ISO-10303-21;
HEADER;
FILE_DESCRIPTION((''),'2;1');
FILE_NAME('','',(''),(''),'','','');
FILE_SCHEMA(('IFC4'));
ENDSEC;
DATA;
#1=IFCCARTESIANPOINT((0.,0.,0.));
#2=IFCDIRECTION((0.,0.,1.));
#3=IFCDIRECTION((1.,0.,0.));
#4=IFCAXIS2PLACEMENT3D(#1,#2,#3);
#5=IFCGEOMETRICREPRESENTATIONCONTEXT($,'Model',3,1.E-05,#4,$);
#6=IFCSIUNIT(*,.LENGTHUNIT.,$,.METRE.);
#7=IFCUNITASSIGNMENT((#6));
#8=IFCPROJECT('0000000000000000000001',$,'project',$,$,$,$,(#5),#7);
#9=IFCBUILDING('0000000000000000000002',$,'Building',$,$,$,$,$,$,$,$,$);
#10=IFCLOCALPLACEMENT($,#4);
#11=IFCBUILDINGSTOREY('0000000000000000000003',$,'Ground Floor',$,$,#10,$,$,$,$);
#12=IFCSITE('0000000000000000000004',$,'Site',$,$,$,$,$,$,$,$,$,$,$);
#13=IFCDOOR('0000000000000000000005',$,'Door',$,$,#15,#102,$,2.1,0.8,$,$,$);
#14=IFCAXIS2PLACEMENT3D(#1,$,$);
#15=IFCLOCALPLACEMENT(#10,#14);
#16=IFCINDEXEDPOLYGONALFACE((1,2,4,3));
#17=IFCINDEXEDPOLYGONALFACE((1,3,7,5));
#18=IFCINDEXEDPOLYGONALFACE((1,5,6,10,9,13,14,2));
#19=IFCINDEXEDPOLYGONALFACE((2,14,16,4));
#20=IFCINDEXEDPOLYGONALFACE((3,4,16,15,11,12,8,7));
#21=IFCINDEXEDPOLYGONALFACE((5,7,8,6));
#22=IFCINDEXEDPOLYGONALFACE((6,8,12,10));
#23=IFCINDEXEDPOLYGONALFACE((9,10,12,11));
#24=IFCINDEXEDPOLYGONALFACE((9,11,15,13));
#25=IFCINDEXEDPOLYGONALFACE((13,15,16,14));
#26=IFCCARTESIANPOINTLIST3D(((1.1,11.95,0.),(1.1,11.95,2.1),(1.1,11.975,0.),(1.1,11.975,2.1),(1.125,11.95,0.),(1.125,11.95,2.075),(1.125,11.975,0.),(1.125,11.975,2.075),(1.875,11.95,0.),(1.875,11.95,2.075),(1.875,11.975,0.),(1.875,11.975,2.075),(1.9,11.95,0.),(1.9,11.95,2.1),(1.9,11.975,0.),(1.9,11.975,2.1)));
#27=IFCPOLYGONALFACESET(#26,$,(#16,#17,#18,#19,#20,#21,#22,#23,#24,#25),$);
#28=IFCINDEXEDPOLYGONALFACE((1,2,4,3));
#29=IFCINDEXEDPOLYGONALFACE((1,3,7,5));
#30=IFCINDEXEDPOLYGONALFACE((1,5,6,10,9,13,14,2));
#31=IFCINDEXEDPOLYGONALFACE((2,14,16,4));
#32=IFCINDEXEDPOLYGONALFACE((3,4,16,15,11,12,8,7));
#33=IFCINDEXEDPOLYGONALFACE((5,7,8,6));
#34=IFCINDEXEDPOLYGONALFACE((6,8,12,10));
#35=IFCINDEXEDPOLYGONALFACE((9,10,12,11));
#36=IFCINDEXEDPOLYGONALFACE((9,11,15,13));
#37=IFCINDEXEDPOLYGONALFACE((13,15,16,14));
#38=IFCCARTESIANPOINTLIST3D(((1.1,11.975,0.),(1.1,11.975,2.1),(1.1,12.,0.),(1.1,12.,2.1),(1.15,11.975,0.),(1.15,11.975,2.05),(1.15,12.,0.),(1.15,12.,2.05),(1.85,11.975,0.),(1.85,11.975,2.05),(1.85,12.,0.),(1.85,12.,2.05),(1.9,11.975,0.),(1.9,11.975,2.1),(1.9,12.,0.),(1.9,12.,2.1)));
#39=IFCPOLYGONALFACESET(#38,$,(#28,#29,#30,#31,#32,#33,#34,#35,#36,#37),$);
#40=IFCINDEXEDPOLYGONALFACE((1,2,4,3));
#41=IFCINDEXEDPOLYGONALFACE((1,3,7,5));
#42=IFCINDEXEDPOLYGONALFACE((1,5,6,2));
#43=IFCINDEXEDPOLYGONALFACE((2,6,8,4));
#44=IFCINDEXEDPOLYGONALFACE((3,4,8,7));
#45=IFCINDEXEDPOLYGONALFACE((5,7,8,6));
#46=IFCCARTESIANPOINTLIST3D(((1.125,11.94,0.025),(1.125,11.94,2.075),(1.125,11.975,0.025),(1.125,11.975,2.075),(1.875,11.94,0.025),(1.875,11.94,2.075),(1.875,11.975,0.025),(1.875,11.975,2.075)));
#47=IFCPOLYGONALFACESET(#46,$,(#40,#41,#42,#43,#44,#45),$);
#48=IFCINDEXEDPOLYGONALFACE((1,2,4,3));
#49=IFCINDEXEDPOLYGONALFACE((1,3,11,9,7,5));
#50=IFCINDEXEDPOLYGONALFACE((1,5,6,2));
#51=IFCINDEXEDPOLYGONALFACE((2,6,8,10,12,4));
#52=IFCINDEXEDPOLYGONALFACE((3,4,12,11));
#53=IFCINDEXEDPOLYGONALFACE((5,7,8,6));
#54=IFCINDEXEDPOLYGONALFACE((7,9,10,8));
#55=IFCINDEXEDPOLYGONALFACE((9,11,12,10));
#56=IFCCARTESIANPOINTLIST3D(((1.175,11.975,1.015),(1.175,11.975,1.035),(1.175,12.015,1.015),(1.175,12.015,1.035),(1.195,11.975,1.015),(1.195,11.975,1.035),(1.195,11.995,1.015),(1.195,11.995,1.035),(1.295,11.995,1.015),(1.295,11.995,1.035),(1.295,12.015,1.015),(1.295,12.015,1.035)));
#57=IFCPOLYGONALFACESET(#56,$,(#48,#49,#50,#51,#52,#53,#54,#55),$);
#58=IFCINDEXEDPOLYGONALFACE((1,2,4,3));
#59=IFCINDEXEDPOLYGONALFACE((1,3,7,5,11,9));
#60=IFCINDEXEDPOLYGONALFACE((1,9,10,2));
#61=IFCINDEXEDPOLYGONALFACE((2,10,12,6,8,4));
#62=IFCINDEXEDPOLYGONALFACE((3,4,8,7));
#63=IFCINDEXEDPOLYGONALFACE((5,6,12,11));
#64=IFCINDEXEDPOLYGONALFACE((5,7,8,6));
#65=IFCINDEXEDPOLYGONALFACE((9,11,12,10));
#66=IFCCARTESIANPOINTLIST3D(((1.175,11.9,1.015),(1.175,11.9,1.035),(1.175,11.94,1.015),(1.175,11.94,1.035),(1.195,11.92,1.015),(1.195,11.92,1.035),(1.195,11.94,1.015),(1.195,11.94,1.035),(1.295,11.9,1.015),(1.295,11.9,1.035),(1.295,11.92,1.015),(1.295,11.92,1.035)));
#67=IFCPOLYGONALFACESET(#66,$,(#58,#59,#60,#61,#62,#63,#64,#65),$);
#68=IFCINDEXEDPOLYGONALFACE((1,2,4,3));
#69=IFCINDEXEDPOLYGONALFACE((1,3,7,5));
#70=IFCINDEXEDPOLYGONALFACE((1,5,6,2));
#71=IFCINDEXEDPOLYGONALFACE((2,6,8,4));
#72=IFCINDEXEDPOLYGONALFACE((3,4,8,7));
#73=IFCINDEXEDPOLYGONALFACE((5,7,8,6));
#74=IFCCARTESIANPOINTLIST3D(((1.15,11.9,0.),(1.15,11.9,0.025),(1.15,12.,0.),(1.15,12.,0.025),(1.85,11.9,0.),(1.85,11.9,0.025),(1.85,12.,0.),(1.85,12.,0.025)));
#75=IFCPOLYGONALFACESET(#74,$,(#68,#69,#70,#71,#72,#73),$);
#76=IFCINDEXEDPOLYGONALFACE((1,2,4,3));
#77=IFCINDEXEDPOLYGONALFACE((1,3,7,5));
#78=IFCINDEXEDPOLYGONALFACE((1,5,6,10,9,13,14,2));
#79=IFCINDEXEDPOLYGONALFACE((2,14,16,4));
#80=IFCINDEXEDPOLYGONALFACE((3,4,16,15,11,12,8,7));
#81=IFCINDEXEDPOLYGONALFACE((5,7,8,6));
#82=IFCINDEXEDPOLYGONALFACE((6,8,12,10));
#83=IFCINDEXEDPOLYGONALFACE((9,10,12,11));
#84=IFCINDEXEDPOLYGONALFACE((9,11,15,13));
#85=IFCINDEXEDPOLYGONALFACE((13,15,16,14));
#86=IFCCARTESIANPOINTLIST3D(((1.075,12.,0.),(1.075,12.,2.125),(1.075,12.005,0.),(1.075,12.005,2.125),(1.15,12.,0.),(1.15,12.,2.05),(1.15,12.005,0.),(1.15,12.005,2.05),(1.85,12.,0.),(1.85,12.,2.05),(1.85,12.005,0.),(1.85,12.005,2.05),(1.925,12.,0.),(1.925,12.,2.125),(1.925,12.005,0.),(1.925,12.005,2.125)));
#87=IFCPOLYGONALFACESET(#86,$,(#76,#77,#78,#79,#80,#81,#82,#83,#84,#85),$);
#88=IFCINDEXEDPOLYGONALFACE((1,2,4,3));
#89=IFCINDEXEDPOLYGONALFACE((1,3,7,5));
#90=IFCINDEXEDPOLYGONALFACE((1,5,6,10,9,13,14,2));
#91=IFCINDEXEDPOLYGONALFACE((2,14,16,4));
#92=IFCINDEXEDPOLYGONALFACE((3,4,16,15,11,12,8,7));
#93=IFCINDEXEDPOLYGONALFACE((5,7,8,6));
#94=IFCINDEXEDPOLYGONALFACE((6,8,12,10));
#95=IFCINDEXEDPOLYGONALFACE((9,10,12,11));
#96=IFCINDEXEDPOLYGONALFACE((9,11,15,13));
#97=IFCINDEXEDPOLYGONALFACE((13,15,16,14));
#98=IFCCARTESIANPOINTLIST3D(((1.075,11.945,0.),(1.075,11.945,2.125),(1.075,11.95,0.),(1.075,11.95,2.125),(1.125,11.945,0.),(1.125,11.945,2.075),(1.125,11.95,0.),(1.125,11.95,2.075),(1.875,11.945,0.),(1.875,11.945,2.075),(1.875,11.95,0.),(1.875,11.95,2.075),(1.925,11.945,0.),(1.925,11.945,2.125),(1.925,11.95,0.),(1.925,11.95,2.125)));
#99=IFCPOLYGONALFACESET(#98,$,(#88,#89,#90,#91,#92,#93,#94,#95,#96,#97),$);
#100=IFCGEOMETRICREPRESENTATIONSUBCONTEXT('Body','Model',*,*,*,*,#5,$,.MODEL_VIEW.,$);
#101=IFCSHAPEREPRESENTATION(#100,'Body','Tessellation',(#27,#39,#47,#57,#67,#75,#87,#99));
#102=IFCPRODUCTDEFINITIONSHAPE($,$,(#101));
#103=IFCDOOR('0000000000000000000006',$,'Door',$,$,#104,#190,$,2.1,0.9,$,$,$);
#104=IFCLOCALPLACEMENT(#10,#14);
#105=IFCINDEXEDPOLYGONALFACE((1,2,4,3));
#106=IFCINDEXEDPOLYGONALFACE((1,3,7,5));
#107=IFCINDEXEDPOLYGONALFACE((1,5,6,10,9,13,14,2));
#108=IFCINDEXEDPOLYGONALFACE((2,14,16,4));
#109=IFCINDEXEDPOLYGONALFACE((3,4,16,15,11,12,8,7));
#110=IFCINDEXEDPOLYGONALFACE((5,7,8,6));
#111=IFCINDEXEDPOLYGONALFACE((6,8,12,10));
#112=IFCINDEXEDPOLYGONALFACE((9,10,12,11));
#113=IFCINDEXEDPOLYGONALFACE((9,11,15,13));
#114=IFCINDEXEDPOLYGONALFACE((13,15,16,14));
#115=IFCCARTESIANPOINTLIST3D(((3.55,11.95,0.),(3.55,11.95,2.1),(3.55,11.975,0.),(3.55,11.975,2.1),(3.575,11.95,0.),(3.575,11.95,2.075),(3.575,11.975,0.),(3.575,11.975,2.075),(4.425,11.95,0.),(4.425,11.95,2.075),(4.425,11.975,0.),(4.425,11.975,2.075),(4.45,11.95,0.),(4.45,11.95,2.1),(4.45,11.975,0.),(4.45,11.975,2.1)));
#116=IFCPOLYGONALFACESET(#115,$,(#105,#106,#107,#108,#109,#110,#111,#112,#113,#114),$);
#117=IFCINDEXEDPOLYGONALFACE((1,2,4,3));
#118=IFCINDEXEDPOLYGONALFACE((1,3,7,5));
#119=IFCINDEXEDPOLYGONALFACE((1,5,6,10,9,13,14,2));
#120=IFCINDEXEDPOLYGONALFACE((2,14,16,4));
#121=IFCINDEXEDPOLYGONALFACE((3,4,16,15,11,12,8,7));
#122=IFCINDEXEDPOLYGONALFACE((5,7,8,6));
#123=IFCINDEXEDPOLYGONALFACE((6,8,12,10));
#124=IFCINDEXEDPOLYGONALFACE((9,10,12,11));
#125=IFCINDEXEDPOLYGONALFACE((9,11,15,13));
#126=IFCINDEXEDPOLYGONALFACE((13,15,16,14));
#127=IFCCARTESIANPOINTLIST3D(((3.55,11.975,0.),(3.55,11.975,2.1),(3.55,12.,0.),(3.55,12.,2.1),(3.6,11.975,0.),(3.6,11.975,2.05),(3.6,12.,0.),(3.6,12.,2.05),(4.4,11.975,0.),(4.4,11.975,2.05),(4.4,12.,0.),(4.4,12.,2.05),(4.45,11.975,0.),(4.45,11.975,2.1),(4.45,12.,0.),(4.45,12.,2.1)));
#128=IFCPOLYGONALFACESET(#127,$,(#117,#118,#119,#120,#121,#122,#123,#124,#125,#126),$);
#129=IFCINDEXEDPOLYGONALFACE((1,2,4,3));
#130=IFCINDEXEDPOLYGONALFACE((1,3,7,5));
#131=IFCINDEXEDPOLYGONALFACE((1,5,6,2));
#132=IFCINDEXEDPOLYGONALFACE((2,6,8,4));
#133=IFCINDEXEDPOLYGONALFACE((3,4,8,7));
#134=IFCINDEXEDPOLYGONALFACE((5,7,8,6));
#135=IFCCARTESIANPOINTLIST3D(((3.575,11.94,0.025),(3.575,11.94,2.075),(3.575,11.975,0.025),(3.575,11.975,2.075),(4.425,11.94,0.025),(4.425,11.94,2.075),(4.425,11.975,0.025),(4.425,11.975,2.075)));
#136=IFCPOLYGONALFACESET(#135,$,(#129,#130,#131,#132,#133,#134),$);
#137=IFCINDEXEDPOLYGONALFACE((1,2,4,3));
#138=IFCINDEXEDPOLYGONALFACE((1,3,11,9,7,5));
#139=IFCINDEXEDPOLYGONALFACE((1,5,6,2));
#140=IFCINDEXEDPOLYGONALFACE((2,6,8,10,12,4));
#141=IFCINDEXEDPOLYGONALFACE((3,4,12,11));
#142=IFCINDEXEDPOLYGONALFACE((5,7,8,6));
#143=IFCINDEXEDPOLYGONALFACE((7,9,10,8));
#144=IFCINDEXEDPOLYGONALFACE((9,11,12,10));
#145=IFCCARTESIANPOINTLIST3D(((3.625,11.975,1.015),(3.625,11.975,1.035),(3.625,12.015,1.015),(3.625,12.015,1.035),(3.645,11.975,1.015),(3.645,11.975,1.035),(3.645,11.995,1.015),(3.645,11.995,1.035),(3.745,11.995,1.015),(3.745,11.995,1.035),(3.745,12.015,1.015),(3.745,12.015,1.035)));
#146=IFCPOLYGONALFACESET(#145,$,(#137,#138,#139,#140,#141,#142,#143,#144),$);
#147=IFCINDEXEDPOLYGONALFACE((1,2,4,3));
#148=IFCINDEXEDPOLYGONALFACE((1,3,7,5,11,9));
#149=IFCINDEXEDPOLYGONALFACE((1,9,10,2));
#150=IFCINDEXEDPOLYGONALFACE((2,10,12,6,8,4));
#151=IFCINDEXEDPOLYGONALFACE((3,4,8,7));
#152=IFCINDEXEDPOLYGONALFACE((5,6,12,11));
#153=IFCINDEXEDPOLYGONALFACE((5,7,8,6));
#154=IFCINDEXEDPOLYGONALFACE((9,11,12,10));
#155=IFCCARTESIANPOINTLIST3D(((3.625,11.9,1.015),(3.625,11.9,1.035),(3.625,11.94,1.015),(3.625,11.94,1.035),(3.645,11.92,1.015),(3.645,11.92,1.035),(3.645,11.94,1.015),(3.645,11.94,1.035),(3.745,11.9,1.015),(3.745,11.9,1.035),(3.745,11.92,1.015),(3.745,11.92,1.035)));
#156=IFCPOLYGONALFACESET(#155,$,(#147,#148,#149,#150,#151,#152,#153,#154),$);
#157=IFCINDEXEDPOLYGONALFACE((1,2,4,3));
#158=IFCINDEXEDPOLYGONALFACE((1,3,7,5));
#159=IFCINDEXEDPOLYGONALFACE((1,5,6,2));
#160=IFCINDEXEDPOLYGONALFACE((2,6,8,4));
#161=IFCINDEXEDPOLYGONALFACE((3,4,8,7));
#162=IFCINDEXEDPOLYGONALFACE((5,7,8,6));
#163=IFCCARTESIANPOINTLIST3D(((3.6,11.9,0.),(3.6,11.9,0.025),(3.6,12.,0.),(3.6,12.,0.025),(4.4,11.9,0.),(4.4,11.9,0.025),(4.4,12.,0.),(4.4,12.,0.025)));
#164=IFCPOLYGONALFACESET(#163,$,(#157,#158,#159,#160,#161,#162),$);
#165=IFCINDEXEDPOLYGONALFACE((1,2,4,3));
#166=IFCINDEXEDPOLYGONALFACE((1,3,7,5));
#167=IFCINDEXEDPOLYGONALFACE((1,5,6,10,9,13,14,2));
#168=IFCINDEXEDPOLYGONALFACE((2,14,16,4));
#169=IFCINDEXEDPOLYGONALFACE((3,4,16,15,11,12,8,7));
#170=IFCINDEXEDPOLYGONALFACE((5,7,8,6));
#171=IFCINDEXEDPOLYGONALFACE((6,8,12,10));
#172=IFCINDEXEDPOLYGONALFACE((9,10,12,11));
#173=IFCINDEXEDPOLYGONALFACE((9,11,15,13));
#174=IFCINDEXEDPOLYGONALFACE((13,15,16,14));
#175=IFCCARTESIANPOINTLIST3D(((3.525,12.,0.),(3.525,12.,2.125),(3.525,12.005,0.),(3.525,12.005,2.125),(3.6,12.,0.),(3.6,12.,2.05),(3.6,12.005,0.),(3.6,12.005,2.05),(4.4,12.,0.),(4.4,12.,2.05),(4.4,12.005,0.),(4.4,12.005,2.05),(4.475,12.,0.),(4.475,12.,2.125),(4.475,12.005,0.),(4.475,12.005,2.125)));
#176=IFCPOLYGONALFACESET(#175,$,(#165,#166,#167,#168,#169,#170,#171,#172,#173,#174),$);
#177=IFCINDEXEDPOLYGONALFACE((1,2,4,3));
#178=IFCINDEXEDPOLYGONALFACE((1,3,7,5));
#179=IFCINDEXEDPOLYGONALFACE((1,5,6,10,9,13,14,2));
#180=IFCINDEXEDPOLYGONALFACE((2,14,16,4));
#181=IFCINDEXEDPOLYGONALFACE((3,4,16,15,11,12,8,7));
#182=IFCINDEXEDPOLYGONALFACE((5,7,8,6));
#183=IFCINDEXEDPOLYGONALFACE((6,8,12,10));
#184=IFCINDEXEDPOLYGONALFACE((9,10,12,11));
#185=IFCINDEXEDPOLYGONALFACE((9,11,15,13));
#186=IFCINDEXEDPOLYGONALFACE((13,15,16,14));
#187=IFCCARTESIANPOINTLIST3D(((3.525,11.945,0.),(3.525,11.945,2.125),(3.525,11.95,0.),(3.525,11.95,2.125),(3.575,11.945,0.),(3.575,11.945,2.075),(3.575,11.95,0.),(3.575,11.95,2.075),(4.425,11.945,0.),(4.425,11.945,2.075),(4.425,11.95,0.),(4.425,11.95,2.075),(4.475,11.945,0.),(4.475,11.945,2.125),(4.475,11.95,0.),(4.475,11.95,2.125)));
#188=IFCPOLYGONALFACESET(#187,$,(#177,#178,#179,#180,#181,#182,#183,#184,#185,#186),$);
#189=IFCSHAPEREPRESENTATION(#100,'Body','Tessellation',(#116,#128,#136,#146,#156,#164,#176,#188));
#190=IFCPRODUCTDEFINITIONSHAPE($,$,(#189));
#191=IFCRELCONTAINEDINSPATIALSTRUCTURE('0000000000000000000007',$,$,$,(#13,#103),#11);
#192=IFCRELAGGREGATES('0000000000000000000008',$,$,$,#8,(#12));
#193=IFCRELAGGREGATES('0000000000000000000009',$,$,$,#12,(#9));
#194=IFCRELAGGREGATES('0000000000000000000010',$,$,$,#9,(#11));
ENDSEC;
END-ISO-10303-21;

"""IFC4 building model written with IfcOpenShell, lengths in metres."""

from ifc_helpers import new_model, si_unit, frame, origin_with_axes, place, context, subcontext, project, spatial, line, indexed_curve, outline, extrude, element, save


model = new_model("IFC4")

# Units and contexts
model_context = context("Model", 3, precision=1e-05, world=origin_with_axes())
body_context = subcontext(model_context, "Body", "Model", "MODEL_VIEW")
ifc_project = project(units=[si_unit("LENGTHUNIT", "METRE")], contexts=[model_context])

# Site, building, storey
site = spatial("IfcSite", under=ifc_project, Name="Site")
building = spatial("IfcBuilding", under=site, Name="Building")
storey_placement = place(None, origin_with_axes())
storey = spatial("IfcBuildingStorey", under=building, at=storey_placement, Name="Ground Floor")

# Doors
door_1_placement = place(storey_placement, frame((1.9, 12.0, 0.0), z_axis=(0.0, 0.0, 1.0), x_axis=(-1.0, 0.0, 0.0)))
element("IfcDoor", 1, at=door_1_placement, inside=storey, Name="Door", OverallHeight=2.1, OverallWidth=0.8, context=body_context, shape_type="SweptSolid", body=[
    extrude(outline(indexed_curve([(0.0, 0.0), (0.0, 2.1), (0.8, 2.1), (0.8, 0.0), (0.775, 0.0), (0.775, 2.075), (0.025, 2.075), (0.025, 0.0)], segments=[line(1, 2, 3, 4, 5, 6, 7, 8, 1)])), frame((0.0, 0.025, 0.0), z_axis=(0.0, -1.0, 0.0), x_axis=(1.0, 0.0, 0.0)), (0.0, 0.0, -1.0), 0.025),
    extrude(outline(indexed_curve([(0.0, 0.0), (0.0, 2.1), (0.8, 2.1), (0.8, 0.0), (0.75, 0.0), (0.75, 2.05), (0.05, 2.05), (0.05, 0.0)], segments=[line(1, 2, 3, 4, 5, 6, 7, 8, 1)])), frame((0.0, 0.0, 0.0), z_axis=(0.0, -1.0, 0.0), x_axis=(1.0, 0.0, 0.0)), (0.0, 0.0, -1.0), 0.025),
    extrude(outline(indexed_curve([(0.0, 0.0), (0.75, 0.0), (0.75, 0.035), (0.0, 0.035)], segments=[line(1, 2, 3, 4, 1)])), frame((0.025, 0.025, 0.025), z_axis=(0.0, 0.0, 1.0), x_axis=(1.0, 0.0, 0.0)), (0.0, 0.0, 1.0), 2.05),
    extrude(outline(indexed_curve([(0.0, 0.0), (0.0, -0.04), (-0.12, -0.04), (-0.12, -0.02), (-0.02, -0.02), (-0.02, 0.0)], segments=[line(1, 2, 3, 4, 5, 6, 1)])), frame((0.725, 0.025, 1.015), z_axis=(0.0, 0.0, 1.0), x_axis=(1.0, 0.0, 0.0)), (0.0, 0.0, 1.0), 0.02),
    extrude(outline(indexed_curve([(0.0, 0.0), (0.0, 0.04), (-0.12, 0.04), (-0.12, 0.02), (-0.02, 0.02), (-0.02, 0.0)], segments=[line(1, 2, 3, 4, 5, 6, 1)])), frame((0.725, 0.06, 1.015), z_axis=(0.0, 0.0, 1.0), x_axis=(1.0, 0.0, 0.0)), (0.0, 0.0, 1.0), 0.02),
    extrude(outline(indexed_curve([(0.0, 0.0), (0.7, 0.0), (0.7, 0.1), (0.0, 0.1)], segments=[line(1, 2, 3, 4, 1)])), frame((0.05, 0.0, 0.0), z_axis=(0.0, 0.0, 1.0), x_axis=(1.0, 0.0, 0.0)), (0.0, 0.0, 1.0), 0.025),
    extrude(outline(indexed_curve([(0.0, 0.0), (0.0, 2.125), (0.85, 2.125), (0.85, 0.0), (0.775, 0.0), (0.775, 2.05), (0.075, 2.05), (0.075, 0.0)], segments=[line(1, 2, 3, 4, 5, 6, 7, 8, 1)])), frame((-0.025, -0.005, 0.0), z_axis=(0.0, -1.0, 0.0), x_axis=(1.0, 0.0, 0.0)), (0.0, 0.0, -1.0), 0.005),
    extrude(outline(indexed_curve([(0.0, 0.0), (0.0, 2.125), (0.85, 2.125), (0.85, 0.0), (0.8, 0.0), (0.8, 2.075), (0.05, 2.075), (0.05, 0.0)], segments=[line(1, 2, 3, 4, 5, 6, 7, 8, 1)])), frame((-0.025, 0.05, 0.0), z_axis=(0.0, -1.0, 0.0), x_axis=(1.0, 0.0, 0.0)), (0.0, 0.0, -1.0), 0.005),
])
door_2_placement = place(storey_placement, frame((4.45, 12.0, 0.0), z_axis=(0.0, 0.0, 1.0), x_axis=(-1.0, 0.0, 0.0)))
element("IfcDoor", 2, at=door_2_placement, inside=storey, Name="Door", OverallHeight=2.1, OverallWidth=0.9, context=body_context, shape_type="SweptSolid", body=[
    extrude(outline(indexed_curve([(0.0, 0.0), (0.0, 2.1), (0.9, 2.1), (0.9, 0.0), (0.875, 0.0), (0.875, 2.075), (0.025, 2.075), (0.025, 0.0)], segments=[line(1, 2, 3, 4, 5, 6, 7, 8, 1)])), frame((0.0, 0.025, 0.0), z_axis=(0.0, -1.0, 0.0), x_axis=(1.0, 0.0, 0.0)), (0.0, 0.0, -1.0), 0.025),
    extrude(outline(indexed_curve([(0.0, 0.0), (0.0, 2.1), (0.9, 2.1), (0.9, 0.0), (0.85, 0.0), (0.85, 2.05), (0.05, 2.05), (0.05, 0.0)], segments=[line(1, 2, 3, 4, 5, 6, 7, 8, 1)])), frame((0.0, 0.0, 0.0), z_axis=(0.0, -1.0, 0.0), x_axis=(1.0, 0.0, 0.0)), (0.0, 0.0, -1.0), 0.025),
    extrude(outline(indexed_curve([(0.0, 0.0), (0.85, 0.0), (0.85, 0.035), (0.0, 0.035)], segments=[line(1, 2, 3, 4, 1)])), frame((0.025, 0.025, 0.025), z_axis=(0.0, 0.0, 1.0), x_axis=(1.0, 0.0, 0.0)), (0.0, 0.0, 1.0), 2.05),
    extrude(outline(indexed_curve([(0.0, 0.0), (0.0, -0.04), (-0.12, -0.04), (-0.12, -0.02), (-0.02, -0.02), (-0.02, 0.0)], segments=[line(1, 2, 3, 4, 5, 6, 1)])), frame((0.825, 0.025, 1.015), z_axis=(0.0, 0.0, 1.0), x_axis=(1.0, 0.0, 0.0)), (0.0, 0.0, 1.0), 0.02),
    extrude(outline(indexed_curve([(0.0, 0.0), (0.0, 0.04), (-0.12, 0.04), (-0.12, 0.02), (-0.02, 0.02), (-0.02, 0.0)], segments=[line(1, 2, 3, 4, 5, 6, 1)])), frame((0.825, 0.06, 1.015), z_axis=(0.0, 0.0, 1.0), x_axis=(1.0, 0.0, 0.0)), (0.0, 0.0, 1.0), 0.02),
    extrude(outline(indexed_curve([(0.0, 0.0), (0.8, 0.0), (0.8, 0.1), (0.0, 0.1)], segments=[line(1, 2, 3, 4, 1)])), frame((0.05, 0.0, 0.0), z_axis=(0.0, 0.0, 1.0), x_axis=(1.0, 0.0, 0.0)), (0.0, 0.0, 1.0), 0.025),
    extrude(outline(indexed_curve([(0.0, 0.0), (0.0, 2.125), (0.95, 2.125), (0.95, 0.0), (0.875, 0.0), (0.875, 2.05), (0.075, 2.05), (0.075, 0.0)], segments=[line(1, 2, 3, 4, 5, 6, 7, 8, 1)])), frame((-0.025, -0.005, 0.0), z_axis=(0.0, -1.0, 0.0), x_axis=(1.0, 0.0, 0.0)), (0.0, 0.0, -1.0), 0.005),
    extrude(outline(indexed_curve([(0.0, 0.0), (0.0, 2.125), (0.95, 2.125), (0.95, 0.0), (0.9, 0.0), (0.9, 2.075), (0.05, 2.075), (0.05, 0.0)], segments=[line(1, 2, 3, 4, 5, 6, 7, 8, 1)])), frame((-0.025, 0.05, 0.0), z_axis=(0.0, -1.0, 0.0), x_axis=(1.0, 0.0, 0.0)), (0.0, 0.0, -1.0), 0.005),
])

save(model, "model.ifc")
